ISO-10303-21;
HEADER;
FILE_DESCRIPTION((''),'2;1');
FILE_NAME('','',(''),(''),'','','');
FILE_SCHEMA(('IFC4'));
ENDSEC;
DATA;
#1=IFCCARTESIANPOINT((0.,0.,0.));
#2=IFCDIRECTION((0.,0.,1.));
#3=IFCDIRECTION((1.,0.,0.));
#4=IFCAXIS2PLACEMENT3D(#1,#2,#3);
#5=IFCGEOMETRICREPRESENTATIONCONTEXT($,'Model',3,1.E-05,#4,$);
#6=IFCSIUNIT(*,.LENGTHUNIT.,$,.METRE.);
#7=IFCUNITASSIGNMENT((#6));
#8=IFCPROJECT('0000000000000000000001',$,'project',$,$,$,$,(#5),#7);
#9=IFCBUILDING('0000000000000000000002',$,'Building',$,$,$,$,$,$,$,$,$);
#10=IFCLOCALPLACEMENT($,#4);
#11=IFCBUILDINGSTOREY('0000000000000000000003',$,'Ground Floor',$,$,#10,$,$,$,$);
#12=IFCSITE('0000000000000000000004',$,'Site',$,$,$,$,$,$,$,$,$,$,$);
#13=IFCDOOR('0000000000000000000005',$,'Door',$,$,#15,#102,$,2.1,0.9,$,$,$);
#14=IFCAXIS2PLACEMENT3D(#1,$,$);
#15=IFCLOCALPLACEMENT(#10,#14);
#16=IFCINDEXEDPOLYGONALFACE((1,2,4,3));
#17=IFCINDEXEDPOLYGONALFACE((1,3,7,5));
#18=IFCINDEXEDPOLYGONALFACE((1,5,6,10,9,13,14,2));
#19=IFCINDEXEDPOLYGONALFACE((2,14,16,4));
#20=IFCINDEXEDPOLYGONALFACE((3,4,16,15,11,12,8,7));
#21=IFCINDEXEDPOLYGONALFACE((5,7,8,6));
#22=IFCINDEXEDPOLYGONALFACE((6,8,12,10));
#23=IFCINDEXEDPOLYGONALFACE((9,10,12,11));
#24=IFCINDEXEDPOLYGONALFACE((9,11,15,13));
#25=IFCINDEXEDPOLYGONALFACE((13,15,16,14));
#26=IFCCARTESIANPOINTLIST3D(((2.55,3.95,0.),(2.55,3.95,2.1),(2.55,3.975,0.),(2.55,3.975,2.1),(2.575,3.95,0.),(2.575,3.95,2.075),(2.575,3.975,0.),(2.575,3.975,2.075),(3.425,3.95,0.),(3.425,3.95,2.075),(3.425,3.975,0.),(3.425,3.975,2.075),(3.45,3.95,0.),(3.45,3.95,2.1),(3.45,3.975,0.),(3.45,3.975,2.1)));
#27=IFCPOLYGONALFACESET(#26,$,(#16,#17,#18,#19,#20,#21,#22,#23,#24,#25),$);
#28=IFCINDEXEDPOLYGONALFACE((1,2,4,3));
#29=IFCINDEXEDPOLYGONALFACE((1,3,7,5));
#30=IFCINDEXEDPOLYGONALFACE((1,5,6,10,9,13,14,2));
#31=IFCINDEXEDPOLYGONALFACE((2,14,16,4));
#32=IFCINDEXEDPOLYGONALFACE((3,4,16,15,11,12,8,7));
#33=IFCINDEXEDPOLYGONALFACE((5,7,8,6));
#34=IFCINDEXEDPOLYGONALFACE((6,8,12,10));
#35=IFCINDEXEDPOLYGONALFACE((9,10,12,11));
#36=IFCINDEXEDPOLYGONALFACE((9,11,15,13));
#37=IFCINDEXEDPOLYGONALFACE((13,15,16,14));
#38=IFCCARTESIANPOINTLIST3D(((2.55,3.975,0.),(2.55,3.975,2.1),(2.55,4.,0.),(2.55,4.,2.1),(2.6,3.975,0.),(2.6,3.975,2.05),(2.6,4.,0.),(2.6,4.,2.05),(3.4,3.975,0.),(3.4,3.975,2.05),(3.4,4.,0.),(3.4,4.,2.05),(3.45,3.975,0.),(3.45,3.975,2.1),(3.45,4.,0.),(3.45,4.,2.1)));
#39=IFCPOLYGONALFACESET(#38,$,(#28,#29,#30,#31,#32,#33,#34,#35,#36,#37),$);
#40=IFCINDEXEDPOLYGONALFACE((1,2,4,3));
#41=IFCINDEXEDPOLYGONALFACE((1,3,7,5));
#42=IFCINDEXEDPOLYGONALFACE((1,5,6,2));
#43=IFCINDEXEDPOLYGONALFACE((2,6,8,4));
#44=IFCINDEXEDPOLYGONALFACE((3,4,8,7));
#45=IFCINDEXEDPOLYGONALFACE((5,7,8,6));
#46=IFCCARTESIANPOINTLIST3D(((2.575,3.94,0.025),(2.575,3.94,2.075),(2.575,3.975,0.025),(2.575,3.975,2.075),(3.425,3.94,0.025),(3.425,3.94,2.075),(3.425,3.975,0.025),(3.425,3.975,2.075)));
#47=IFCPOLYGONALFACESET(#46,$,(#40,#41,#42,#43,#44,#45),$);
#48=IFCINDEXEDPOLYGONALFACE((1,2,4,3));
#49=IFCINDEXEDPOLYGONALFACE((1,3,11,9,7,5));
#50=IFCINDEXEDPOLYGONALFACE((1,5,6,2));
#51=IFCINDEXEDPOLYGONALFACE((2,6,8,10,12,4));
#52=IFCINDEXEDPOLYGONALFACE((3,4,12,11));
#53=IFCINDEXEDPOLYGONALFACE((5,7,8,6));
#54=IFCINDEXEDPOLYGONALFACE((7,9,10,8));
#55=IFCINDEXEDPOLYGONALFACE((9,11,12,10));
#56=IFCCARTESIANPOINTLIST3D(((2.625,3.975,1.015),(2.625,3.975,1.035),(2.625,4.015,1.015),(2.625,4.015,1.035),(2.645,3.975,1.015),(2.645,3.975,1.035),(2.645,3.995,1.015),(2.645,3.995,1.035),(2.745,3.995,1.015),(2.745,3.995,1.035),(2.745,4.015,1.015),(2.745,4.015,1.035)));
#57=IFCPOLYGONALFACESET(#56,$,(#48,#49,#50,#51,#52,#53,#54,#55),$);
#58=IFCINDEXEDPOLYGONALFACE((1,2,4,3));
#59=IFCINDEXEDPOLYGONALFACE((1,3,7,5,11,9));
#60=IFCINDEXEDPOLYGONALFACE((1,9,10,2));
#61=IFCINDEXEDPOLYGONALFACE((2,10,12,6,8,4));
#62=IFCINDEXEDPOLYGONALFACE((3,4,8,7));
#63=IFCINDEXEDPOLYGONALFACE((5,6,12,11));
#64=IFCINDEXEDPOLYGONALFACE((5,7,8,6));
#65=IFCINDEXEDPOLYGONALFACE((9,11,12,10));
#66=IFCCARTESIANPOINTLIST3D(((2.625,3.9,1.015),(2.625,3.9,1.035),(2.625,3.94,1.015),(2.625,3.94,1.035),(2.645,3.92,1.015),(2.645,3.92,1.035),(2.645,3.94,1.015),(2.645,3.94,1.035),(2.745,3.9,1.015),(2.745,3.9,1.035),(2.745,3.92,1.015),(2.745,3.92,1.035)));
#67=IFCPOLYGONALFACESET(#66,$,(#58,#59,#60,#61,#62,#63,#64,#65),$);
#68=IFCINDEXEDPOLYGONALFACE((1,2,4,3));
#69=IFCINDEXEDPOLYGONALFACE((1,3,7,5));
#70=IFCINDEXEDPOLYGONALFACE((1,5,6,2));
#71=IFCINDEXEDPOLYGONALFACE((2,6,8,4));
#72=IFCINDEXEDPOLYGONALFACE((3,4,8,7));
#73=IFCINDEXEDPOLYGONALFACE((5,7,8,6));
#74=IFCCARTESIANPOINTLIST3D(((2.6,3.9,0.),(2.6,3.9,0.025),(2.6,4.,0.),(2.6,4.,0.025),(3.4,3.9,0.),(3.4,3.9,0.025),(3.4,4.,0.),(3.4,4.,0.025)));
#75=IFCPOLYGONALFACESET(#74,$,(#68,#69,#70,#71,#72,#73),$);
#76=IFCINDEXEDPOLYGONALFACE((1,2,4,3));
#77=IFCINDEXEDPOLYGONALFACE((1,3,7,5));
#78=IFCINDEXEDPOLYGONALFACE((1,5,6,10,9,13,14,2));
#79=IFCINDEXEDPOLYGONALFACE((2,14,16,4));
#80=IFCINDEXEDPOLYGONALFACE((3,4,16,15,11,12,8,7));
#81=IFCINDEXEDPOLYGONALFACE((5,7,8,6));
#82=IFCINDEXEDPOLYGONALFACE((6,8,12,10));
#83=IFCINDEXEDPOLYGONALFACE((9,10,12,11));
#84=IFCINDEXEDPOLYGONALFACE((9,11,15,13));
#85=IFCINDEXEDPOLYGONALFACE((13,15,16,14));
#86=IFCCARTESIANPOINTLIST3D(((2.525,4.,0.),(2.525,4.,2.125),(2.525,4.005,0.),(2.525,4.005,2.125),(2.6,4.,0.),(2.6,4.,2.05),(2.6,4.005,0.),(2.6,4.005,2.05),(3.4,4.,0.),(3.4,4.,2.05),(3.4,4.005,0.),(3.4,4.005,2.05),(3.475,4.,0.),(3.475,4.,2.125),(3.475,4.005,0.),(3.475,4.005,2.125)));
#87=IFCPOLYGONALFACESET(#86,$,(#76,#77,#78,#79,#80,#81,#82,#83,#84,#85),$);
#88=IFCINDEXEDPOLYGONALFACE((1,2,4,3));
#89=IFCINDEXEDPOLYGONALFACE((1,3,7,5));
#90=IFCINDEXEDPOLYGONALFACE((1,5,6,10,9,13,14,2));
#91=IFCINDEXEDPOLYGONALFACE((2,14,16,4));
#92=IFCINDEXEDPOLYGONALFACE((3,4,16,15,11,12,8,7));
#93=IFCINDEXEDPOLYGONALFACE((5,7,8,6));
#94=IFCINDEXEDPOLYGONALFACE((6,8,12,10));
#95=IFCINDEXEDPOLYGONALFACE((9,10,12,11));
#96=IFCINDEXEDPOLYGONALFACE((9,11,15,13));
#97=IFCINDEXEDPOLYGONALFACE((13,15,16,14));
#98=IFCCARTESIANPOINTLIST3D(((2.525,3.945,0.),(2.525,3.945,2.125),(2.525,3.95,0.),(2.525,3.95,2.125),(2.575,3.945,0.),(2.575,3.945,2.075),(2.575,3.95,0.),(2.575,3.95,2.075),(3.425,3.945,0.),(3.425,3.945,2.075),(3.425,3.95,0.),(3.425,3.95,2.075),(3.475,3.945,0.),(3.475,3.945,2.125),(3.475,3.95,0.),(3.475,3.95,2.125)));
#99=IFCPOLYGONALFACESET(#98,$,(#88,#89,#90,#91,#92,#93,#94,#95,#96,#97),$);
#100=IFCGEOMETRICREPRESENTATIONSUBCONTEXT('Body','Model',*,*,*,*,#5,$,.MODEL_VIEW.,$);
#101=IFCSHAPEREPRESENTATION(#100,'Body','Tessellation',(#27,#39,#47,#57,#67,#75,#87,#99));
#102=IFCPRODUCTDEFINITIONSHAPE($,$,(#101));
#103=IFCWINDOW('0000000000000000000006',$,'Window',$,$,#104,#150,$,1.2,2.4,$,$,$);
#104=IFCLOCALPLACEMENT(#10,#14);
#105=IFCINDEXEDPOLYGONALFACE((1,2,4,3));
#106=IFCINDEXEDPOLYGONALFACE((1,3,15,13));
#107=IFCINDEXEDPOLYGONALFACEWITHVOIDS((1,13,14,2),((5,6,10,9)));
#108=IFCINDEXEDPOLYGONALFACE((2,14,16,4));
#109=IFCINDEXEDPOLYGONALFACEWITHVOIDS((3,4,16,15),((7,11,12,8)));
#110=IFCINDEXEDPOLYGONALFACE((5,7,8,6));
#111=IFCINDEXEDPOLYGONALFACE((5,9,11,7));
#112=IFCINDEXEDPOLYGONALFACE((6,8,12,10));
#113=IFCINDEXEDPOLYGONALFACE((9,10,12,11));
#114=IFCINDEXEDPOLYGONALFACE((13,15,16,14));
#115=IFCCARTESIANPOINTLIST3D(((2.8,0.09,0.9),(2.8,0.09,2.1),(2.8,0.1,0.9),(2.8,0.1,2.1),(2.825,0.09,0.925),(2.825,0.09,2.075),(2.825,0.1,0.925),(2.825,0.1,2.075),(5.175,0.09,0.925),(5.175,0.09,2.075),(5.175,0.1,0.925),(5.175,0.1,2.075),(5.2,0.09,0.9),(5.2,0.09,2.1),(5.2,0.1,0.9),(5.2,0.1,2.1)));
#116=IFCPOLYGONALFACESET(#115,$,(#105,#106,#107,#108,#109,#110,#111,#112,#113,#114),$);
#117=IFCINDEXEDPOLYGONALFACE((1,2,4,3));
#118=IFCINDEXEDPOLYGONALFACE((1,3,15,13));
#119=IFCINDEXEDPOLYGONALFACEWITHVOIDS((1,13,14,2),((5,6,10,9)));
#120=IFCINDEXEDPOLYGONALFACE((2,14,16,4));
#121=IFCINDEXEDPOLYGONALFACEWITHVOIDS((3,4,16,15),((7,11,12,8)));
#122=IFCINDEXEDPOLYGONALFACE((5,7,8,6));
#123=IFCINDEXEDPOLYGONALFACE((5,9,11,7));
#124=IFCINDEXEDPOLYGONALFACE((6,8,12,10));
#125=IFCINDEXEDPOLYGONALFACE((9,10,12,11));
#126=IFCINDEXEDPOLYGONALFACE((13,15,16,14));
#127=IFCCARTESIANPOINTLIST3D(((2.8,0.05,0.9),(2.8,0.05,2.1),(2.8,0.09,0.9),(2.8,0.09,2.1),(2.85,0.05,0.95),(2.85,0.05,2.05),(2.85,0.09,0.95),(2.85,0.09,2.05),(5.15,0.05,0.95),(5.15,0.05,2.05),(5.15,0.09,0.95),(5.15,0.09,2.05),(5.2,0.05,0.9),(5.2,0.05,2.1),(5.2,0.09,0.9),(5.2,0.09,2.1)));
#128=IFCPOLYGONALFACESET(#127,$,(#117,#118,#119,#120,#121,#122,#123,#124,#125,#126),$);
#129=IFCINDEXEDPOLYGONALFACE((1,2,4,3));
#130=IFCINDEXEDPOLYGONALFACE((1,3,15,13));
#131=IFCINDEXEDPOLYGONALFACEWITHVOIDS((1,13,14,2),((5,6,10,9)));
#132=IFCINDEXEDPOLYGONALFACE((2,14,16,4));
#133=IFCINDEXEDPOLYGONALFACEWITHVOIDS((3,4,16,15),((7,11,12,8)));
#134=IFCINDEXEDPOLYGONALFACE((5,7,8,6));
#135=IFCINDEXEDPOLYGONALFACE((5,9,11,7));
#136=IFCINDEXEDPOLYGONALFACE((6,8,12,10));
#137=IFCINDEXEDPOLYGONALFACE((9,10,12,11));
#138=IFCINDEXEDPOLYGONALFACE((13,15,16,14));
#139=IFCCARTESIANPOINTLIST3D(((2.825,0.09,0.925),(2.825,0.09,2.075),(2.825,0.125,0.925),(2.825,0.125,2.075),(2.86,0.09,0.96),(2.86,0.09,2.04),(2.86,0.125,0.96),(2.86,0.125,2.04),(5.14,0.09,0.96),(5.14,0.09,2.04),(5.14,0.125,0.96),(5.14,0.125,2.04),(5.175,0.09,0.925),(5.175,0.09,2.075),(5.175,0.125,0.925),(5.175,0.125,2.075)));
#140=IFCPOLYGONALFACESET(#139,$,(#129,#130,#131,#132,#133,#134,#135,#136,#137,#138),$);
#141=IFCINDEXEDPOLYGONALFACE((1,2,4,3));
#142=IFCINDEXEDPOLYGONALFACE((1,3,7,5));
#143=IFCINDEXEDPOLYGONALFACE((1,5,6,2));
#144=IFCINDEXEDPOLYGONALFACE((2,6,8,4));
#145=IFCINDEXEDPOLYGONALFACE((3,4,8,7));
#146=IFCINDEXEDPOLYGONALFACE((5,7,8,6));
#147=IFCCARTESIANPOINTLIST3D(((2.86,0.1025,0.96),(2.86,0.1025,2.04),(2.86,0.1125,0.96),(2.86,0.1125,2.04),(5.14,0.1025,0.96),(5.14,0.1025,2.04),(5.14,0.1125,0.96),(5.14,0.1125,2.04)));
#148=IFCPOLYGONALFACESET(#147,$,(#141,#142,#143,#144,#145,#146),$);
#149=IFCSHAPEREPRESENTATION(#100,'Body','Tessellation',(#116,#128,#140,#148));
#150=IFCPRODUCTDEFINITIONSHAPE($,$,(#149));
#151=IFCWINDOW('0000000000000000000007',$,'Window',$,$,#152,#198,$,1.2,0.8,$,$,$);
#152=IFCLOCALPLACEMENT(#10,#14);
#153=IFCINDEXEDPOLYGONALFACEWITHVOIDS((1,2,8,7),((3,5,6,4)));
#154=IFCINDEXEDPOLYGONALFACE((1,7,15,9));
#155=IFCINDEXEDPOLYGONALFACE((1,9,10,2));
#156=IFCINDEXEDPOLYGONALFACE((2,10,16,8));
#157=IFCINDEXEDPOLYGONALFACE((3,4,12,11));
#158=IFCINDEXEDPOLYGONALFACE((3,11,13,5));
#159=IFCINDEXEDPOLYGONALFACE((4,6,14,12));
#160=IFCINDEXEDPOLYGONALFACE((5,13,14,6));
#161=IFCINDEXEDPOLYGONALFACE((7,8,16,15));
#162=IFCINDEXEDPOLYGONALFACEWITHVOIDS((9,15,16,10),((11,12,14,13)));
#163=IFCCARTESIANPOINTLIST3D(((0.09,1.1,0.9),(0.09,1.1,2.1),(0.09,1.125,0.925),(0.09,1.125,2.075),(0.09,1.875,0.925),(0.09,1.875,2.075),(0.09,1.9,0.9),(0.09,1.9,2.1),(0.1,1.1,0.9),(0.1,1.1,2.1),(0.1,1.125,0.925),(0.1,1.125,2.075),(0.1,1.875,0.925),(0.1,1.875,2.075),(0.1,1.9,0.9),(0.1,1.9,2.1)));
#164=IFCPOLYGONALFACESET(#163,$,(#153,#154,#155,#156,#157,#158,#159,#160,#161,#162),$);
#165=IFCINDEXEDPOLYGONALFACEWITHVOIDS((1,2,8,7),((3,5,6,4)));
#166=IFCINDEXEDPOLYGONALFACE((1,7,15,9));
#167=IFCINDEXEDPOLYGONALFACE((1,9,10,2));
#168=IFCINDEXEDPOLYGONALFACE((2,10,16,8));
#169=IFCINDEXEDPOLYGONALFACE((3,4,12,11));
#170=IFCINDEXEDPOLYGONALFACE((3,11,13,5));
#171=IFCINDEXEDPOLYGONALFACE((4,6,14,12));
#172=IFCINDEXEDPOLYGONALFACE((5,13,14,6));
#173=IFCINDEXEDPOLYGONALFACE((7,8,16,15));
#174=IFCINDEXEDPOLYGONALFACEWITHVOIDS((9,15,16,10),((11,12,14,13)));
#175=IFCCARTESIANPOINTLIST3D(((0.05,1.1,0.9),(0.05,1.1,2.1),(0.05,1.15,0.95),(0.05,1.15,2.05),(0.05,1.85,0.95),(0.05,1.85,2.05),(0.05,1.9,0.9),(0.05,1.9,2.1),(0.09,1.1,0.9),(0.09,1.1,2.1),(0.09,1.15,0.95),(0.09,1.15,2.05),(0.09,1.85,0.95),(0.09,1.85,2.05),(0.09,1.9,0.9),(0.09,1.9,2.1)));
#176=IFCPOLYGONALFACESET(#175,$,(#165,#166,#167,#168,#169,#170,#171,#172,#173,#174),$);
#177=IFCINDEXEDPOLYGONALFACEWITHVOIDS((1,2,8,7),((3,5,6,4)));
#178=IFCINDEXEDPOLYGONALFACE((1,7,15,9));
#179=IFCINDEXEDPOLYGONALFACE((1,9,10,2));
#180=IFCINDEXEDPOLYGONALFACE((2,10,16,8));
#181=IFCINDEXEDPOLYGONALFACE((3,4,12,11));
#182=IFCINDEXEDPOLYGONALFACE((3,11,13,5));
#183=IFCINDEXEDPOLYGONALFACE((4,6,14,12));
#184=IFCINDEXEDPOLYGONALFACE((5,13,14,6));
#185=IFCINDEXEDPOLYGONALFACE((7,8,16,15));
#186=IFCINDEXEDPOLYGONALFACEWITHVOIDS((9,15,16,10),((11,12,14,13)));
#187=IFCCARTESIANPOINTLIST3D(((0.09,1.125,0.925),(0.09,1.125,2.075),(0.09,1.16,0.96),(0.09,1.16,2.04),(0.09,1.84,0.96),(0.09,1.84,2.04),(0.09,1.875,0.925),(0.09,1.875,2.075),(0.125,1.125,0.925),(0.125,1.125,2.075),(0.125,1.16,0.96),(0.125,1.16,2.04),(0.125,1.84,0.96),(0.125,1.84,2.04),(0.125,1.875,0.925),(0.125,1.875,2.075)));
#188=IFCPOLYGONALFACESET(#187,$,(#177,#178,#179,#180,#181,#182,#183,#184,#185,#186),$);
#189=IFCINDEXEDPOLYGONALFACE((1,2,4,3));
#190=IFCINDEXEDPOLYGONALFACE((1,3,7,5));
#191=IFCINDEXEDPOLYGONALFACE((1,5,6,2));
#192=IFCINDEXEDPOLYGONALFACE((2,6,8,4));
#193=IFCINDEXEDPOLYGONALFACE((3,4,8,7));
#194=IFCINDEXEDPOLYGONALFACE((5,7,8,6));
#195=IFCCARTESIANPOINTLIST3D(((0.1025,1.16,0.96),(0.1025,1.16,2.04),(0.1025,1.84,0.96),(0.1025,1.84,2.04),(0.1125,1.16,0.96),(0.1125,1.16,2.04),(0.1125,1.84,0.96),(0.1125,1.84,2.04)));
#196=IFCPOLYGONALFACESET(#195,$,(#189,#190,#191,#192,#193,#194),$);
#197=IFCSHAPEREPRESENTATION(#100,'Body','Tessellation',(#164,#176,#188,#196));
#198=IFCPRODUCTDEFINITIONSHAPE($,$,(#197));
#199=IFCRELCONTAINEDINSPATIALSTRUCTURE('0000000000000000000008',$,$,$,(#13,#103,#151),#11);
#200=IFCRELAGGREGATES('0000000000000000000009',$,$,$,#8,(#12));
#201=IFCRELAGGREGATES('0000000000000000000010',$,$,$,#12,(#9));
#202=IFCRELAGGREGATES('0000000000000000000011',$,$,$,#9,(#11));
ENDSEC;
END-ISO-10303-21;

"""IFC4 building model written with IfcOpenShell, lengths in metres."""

from ifc_helpers import new_model, si_unit, frame, origin_with_axes, place, context, subcontext, project, spatial, line, indexed_curve, outline, extrude, element, save


model = new_model("IFC4")

# Units and contexts
model_context = context("Model", 3, precision=1e-05, world=origin_with_axes())
body_context = subcontext(model_context, "Body", "Model", "MODEL_VIEW")
ifc_project = project(units=[si_unit("LENGTHUNIT", "METRE")], contexts=[model_context])

# Site, building, storey
site = spatial("IfcSite", under=ifc_project, Name="Site")
building = spatial("IfcBuilding", under=site, Name="Building")
storey_placement = place(None, origin_with_axes())
storey = spatial("IfcBuildingStorey", under=building, at=storey_placement, Name="Ground Floor")

# Door
door_1_placement = place(storey_placement, frame((3.45, 4.0, 0.0), z_axis=(0.0, 0.0, 1.0), x_axis=(-1.0, 0.0, 0.0)))
element("IfcDoor", 1, at=door_1_placement, inside=storey, Name="Door", OverallHeight=2.1, OverallWidth=0.9, context=body_context, shape_type="SweptSolid", body=[
    extrude(outline(indexed_curve([(0.0, 0.0), (0.0, 2.1), (0.9, 2.1), (0.9, 0.0), (0.875, 0.0), (0.875, 2.075), (0.025, 2.075), (0.025, 0.0)], segments=[line(1, 2, 3, 4, 5, 6, 7, 8, 1)])), frame((0.0, 0.025, 0.0), z_axis=(0.0, -1.0, 0.0), x_axis=(1.0, 0.0, 0.0)), (0.0, 0.0, -1.0), 0.025),
    extrude(outline(indexed_curve([(0.0, 0.0), (0.0, 2.1), (0.9, 2.1), (0.9, 0.0), (0.85, 0.0), (0.85, 2.05), (0.05, 2.05), (0.05, 0.0)], segments=[line(1, 2, 3, 4, 5, 6, 7, 8, 1)])), frame((0.0, 0.0, 0.0), z_axis=(0.0, -1.0, 0.0), x_axis=(1.0, 0.0, 0.0)), (0.0, 0.0, -1.0), 0.025),
    extrude(outline(indexed_curve([(0.0, 0.0), (0.85, 0.0), (0.85, 0.035), (0.0, 0.035)], segments=[line(1, 2, 3, 4, 1)])), frame((0.025, 0.025, 0.025), z_axis=(0.0, 0.0, 1.0), x_axis=(1.0, 0.0, 0.0)), (0.0, 0.0, 1.0), 2.05),
    extrude(outline(indexed_curve([(0.0, 0.0), (0.0, -0.04), (-0.12, -0.04), (-0.12, -0.02), (-0.02, -0.02), (-0.02, 0.0)], segments=[line(1, 2, 3, 4, 5, 6, 1)])), frame((0.825, 0.025, 1.015), z_axis=(0.0, 0.0, 1.0), x_axis=(1.0, 0.0, 0.0)), (0.0, 0.0, 1.0), 0.02),
    extrude(outline(indexed_curve([(0.0, 0.0), (0.0, 0.04), (-0.12, 0.04), (-0.12, 0.02), (-0.02, 0.02), (-0.02, 0.0)], segments=[line(1, 2, 3, 4, 5, 6, 1)])), frame((0.825, 0.06, 1.015), z_axis=(0.0, 0.0, 1.0), x_axis=(1.0, 0.0, 0.0)), (0.0, 0.0, 1.0), 0.02),
    extrude(outline(indexed_curve([(0.0, 0.0), (0.8, 0.0), (0.8, 0.1), (0.0, 0.1)], segments=[line(1, 2, 3, 4, 1)])), frame((0.05, 0.0, 0.0), z_axis=(0.0, 0.0, 1.0), x_axis=(1.0, 0.0, 0.0)), (0.0, 0.0, 1.0), 0.025),
    extrude(outline(indexed_curve([(0.0, 0.0), (0.0, 2.125), (0.95, 2.125), (0.95, 0.0), (0.875, 0.0), (0.875, 2.05), (0.075, 2.05), (0.075, 0.0)], segments=[line(1, 2, 3, 4, 5, 6, 7, 8, 1)])), frame((-0.025, -0.005, 0.0), z_axis=(0.0, -1.0, 0.0), x_axis=(1.0, 0.0, 0.0)), (0.0, 0.0, -1.0), 0.005),
    extrude(outline(indexed_curve([(0.0, 0.0), (0.0, 2.125), (0.95, 2.125), (0.95, 0.0), (0.9, 0.0), (0.9, 2.075), (0.05, 2.075), (0.05, 0.0)], segments=[line(1, 2, 3, 4, 5, 6, 7, 8, 1)])), frame((-0.025, 0.05, 0.0), z_axis=(0.0, -1.0, 0.0), x_axis=(1.0, 0.0, 0.0)), (0.0, 0.0, -1.0), 0.005),
])

# Windows
window_1_placement = place(storey_placement, frame((2.8, 0.0, 0.9), z_axis=(0.0, 0.0, 1.0), x_axis=(1.0, 0.0, 0.0)))
element("IfcWindow", 2, at=window_1_placement, inside=storey, Name="Window", OverallHeight=1.2, OverallWidth=2.4, context=body_context, shape_type="SweptSolid", body=[
    extrude(outline(indexed_curve([(0.0, 0.0), (2.4, 0.0), (2.4, 1.2), (0.0, 1.2)], segments=[line(1, 2, 3, 4, 1)]), holes=[indexed_curve([(0.025, 0.025), (2.375, 0.025), (2.375, 1.175), (0.025, 1.175)], segments=[line(1, 2, 3, 4, 1)])]), frame((0.0, 0.09, 0.0), z_axis=(0.0, -1.0, 0.0), x_axis=(1.0, 0.0, 0.0)), (0.0, 0.0, -1.0), 0.01),
    extrude(outline(indexed_curve([(0.0, 0.0), (2.4, 0.0), (2.4, 1.2), (0.0, 1.2)], segments=[line(1, 2, 3, 4, 1)]), holes=[indexed_curve([(0.05, 0.05), (2.35, 0.05), (2.35, 1.15), (0.05, 1.15)], segments=[line(1, 2, 3, 4, 1)])]), frame((0.0, 0.05, 0.0), z_axis=(0.0, -1.0, 0.0), x_axis=(1.0, 0.0, 0.0)), (0.0, 0.0, -1.0), 0.04),
    extrude(outline(indexed_curve([(0.0, 0.0), (2.35, 0.0), (2.35, 1.15), (0.0, 1.15)], segments=[line(1, 2, 3, 4, 1)]), holes=[indexed_curve([(0.035, 0.035), (2.315, 0.035), (2.315, 1.115), (0.035, 1.115)], segments=[line(1, 2, 3, 4, 1)])]), frame((0.025, 0.09, 0.025), z_axis=(0.0, -1.0, 0.0), x_axis=(1.0, 0.0, 0.0)), (0.0, 0.0, -1.0), 0.035),
    extrude(outline(indexed_curve([(0.035, 0.035), (2.315, 0.035), (2.315, 1.115), (0.035, 1.115)], segments=[line(1, 2, 3, 4, 1)])), frame((0.025, 0.1025, 0.025), z_axis=(0.0, -1.0, 0.0), x_axis=(1.0, 0.0, 0.0)), (0.0, 0.0, -1.0), 0.01),
])
window_2_placement = place(storey_placement, frame((0.0, 1.9, 0.9), z_axis=(0.0, 0.0, 1.0), x_axis=(0.0, -1.0, 0.0)))
element("IfcWindow", 3, at=window_2_placement, inside=storey, Name="Window", OverallHeight=1.2, OverallWidth=0.8, context=body_context, shape_type="SweptSolid", body=[
    extrude(outline(indexed_curve([(0.0, 0.0), (0.8, 0.0), (0.8, 1.2), (0.0, 1.2)], segments=[line(1, 2, 3, 4, 1)]), holes=[indexed_curve([(0.025, 0.025), (0.775, 0.025), (0.775, 1.175), (0.025, 1.175)], segments=[line(1, 2, 3, 4, 1)])]), frame((0.0, 0.09, 0.0), z_axis=(0.0, -1.0, 0.0), x_axis=(1.0, 0.0, 0.0)), (0.0, 0.0, -1.0), 0.01),
    extrude(outline(indexed_curve([(0.0, 0.0), (0.8, 0.0), (0.8, 1.2), (0.0, 1.2)], segments=[line(1, 2, 3, 4, 1)]), holes=[indexed_curve([(0.05, 0.05), (0.75, 0.05), (0.75, 1.15), (0.05, 1.15)], segments=[line(1, 2, 3, 4, 1)])]), frame((0.0, 0.05, 0.0), z_axis=(0.0, -1.0, 0.0), x_axis=(1.0, 0.0, 0.0)), (0.0, 0.0, -1.0), 0.04),
    extrude(outline(indexed_curve([(0.0, 0.0), (0.75, 0.0), (0.75, 1.15), (0.0, 1.15)], segments=[line(1, 2, 3, 4, 1)]), holes=[indexed_curve([(0.035, 0.035), (0.715, 0.035), (0.715, 1.115), (0.035, 1.115)], segments=[line(1, 2, 3, 4, 1)])]), frame((0.025, 0.09, 0.025), z_axis=(0.0, -1.0, 0.0), x_axis=(1.0, 0.0, 0.0)), (0.0, 0.0, -1.0), 0.035),
    extrude(outline(indexed_curve([(0.035, 0.035), (0.715, 0.035), (0.715, 1.115), (0.035, 1.115)], segments=[line(1, 2, 3, 4, 1)])), frame((0.025, 0.1025, 0.025), z_axis=(0.0, -1.0, 0.0), x_axis=(1.0, 0.0, 0.0)), (0.0, 0.0, -1.0), 0.01),
])

save(model, "model.ifc")
